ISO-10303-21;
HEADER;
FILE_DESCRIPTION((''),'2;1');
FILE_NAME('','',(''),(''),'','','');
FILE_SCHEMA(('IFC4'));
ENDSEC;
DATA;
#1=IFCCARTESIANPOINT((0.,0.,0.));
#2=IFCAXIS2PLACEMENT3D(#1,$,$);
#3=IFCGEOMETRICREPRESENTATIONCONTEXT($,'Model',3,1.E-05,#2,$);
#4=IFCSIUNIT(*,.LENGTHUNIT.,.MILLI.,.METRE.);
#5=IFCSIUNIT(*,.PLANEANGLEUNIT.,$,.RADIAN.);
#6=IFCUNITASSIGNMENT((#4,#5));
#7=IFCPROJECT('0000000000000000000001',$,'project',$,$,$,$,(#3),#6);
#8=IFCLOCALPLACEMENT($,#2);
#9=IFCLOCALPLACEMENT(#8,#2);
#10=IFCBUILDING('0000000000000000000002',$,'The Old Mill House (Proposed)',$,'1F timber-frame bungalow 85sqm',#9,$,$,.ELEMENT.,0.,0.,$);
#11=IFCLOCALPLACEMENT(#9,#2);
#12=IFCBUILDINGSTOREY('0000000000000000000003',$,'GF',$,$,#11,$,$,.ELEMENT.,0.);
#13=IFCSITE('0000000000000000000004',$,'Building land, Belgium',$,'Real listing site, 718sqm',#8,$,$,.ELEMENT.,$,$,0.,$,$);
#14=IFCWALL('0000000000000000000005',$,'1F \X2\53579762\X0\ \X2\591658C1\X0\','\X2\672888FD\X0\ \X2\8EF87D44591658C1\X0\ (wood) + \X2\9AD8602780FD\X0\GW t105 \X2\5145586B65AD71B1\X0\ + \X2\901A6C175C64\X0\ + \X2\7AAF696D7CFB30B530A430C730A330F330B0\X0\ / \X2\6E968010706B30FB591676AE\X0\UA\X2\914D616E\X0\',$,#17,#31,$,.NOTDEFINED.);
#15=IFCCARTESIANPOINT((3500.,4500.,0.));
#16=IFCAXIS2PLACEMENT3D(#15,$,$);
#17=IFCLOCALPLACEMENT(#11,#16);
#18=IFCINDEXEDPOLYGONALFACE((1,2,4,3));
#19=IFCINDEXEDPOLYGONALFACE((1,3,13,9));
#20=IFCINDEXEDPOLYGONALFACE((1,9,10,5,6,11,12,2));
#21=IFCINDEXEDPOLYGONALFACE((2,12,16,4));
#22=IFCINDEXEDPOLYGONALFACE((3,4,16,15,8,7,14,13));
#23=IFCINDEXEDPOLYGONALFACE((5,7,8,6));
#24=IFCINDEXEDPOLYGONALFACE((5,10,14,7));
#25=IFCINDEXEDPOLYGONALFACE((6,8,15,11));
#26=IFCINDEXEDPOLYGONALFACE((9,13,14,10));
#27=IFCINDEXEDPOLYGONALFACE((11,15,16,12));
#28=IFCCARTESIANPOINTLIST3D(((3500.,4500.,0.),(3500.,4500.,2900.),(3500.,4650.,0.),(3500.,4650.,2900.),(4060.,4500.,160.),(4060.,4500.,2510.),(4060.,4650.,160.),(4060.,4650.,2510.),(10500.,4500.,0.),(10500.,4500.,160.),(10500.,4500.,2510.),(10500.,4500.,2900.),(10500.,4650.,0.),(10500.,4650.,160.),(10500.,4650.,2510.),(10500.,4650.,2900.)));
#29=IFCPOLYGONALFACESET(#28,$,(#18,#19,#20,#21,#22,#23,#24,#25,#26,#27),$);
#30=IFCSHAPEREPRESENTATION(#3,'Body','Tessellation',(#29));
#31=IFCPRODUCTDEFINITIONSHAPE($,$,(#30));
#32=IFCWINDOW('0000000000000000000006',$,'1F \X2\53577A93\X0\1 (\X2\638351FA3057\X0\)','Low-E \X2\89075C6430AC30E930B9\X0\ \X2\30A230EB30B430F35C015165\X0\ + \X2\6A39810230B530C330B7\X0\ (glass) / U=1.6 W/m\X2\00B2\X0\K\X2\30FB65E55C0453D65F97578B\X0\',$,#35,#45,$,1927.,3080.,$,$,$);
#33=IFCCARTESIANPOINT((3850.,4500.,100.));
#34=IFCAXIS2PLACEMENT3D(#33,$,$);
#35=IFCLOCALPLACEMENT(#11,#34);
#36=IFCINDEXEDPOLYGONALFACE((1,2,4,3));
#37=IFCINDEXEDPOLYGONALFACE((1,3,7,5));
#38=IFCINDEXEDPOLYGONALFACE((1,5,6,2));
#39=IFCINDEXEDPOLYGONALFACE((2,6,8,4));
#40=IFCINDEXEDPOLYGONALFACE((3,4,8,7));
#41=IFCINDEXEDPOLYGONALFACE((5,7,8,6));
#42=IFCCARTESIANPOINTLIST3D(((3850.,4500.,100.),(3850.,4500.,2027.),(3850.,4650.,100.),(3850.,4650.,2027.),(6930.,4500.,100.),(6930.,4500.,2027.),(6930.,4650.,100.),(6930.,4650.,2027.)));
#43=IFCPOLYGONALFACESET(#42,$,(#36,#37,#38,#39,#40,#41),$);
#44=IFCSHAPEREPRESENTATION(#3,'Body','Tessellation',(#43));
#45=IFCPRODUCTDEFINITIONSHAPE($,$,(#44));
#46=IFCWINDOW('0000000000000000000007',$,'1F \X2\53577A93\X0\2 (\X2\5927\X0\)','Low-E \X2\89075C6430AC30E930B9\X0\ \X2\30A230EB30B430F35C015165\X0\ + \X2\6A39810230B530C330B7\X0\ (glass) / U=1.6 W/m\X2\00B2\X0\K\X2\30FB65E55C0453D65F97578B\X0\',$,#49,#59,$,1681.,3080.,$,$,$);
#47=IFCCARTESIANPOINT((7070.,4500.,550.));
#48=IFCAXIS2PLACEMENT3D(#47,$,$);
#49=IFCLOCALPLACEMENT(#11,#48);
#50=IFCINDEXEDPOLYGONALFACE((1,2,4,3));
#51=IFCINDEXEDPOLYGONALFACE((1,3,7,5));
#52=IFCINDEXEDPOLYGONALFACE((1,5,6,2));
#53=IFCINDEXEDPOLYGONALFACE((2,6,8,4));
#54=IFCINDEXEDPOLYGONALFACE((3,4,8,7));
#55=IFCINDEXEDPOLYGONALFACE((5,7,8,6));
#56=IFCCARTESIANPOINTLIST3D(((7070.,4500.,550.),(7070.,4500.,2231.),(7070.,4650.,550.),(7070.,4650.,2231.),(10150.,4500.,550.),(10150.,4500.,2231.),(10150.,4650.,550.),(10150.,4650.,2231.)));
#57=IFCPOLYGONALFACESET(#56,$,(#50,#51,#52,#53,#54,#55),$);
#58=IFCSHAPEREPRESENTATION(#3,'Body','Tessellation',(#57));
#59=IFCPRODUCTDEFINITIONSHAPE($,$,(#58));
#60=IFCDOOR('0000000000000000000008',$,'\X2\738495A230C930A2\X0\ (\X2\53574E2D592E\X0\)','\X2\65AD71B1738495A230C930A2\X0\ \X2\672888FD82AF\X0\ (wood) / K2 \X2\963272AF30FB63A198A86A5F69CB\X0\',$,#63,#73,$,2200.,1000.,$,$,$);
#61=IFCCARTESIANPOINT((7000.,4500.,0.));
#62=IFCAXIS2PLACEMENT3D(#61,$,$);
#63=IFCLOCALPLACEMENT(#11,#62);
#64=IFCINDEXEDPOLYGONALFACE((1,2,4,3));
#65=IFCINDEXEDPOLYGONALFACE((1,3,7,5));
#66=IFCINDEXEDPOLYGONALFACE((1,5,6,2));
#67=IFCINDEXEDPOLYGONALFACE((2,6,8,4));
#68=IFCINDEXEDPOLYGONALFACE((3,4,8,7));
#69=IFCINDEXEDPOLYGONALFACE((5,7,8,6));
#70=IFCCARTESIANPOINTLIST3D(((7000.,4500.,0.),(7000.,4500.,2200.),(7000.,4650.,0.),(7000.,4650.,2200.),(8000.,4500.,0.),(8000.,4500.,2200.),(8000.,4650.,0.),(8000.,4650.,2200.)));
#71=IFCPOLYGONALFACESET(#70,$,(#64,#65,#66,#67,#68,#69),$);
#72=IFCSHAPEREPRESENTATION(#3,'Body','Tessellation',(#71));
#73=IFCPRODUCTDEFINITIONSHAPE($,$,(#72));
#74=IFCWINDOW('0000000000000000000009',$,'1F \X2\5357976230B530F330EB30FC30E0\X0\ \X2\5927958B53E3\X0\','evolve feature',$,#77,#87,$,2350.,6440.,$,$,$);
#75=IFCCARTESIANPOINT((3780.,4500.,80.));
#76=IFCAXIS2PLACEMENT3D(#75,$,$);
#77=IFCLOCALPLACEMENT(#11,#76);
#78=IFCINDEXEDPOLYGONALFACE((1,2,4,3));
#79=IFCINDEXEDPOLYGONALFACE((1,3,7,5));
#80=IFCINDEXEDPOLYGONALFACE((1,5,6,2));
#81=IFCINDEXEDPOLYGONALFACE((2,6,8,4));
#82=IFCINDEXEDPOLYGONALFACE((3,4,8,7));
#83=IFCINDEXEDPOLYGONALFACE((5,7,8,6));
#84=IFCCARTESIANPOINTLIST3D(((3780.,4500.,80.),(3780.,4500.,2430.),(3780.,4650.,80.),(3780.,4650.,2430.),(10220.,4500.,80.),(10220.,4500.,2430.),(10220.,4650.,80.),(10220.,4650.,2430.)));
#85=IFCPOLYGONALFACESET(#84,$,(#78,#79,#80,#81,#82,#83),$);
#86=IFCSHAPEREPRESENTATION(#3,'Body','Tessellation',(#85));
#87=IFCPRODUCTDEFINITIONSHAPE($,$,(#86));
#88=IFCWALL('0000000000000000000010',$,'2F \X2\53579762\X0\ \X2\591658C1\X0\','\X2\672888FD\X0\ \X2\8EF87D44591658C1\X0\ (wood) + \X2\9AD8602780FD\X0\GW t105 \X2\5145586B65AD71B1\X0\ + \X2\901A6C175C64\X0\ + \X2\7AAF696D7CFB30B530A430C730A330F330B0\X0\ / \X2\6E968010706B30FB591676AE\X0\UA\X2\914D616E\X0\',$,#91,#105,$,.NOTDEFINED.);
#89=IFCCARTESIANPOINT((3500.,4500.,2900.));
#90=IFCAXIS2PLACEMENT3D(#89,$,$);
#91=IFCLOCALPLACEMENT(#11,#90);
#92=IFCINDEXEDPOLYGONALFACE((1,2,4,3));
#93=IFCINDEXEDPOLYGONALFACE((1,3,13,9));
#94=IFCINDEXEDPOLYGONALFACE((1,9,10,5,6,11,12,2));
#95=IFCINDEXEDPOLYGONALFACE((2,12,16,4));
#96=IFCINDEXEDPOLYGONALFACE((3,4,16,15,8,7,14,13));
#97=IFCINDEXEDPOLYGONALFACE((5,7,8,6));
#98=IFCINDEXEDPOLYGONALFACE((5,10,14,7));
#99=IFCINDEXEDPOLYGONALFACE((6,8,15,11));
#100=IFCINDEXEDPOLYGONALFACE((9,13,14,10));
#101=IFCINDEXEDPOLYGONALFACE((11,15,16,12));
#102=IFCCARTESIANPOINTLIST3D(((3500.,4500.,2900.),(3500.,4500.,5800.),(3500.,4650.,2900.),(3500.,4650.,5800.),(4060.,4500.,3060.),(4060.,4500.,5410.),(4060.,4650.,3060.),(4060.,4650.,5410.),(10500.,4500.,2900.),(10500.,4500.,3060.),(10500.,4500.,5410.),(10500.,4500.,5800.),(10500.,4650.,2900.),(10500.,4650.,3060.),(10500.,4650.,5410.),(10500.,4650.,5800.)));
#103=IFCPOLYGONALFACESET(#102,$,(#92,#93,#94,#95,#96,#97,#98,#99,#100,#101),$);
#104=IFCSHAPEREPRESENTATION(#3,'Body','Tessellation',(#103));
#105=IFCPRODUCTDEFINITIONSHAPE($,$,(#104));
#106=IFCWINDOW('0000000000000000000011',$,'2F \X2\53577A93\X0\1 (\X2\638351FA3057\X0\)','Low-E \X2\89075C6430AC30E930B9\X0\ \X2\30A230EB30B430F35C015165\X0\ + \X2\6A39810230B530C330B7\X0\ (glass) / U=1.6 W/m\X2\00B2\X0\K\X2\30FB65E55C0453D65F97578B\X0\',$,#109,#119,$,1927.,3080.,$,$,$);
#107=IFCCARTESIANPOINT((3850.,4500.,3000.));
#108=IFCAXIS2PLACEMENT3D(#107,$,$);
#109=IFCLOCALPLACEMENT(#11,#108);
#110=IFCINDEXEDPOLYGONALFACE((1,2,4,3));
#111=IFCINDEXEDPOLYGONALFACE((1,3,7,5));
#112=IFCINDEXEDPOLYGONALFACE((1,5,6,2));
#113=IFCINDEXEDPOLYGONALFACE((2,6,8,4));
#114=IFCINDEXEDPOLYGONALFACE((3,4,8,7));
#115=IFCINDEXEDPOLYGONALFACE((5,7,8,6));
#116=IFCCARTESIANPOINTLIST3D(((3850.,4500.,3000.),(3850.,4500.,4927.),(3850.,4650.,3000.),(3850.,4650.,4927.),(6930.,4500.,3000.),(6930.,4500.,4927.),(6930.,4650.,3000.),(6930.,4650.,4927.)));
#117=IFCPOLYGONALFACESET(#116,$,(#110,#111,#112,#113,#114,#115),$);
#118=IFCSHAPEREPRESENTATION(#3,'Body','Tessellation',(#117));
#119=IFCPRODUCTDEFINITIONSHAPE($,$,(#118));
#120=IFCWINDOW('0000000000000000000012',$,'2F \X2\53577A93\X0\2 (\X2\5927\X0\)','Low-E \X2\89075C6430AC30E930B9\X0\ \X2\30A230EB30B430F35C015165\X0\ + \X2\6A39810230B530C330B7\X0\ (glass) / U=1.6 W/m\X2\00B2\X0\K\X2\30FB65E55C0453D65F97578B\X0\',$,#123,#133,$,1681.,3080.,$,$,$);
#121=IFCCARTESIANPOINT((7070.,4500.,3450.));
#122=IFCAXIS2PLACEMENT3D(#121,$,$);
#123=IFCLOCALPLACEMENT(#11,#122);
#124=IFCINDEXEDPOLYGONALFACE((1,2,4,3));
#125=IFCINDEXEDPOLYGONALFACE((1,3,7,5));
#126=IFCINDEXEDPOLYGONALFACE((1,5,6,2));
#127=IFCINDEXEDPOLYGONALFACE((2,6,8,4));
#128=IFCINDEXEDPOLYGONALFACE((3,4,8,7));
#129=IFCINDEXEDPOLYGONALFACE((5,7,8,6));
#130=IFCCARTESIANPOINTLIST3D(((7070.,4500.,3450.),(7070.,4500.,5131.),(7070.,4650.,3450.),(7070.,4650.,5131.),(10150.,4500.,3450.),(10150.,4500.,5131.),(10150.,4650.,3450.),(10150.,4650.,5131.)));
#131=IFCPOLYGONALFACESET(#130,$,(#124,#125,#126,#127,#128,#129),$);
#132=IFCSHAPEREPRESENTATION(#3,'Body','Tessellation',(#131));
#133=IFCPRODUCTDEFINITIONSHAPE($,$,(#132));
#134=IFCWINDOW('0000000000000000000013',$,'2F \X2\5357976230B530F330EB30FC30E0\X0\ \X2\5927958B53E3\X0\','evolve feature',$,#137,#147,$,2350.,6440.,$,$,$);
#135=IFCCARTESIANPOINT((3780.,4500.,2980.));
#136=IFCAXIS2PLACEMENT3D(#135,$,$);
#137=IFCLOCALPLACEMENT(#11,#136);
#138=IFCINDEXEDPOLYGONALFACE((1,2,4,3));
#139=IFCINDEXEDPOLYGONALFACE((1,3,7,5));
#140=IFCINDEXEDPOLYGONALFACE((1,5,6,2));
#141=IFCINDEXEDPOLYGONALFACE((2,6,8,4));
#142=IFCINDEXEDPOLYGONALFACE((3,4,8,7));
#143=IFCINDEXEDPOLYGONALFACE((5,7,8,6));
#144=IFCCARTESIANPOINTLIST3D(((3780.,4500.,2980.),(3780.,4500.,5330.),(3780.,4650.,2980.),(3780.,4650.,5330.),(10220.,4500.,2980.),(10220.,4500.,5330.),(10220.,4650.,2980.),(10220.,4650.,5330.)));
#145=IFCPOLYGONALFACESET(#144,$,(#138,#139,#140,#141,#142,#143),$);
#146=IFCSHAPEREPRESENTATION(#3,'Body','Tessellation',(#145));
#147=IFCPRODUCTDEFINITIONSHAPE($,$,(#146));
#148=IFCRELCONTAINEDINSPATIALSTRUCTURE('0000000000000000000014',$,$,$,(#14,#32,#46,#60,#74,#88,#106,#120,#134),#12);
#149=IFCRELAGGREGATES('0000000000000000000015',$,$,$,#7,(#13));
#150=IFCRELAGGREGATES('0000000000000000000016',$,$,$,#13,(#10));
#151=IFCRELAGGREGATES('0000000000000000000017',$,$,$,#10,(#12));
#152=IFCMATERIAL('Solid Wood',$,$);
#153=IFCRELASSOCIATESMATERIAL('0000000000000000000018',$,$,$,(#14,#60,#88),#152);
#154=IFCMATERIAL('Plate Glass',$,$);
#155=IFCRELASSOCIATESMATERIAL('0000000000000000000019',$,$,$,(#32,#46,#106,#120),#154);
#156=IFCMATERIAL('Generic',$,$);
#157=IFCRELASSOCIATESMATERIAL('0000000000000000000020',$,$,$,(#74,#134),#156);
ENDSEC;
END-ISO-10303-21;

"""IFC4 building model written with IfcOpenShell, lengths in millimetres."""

from ifc_helpers import new_model, si_unit, frame, frame_2d, origin, place, context, project, spatial, rectangle, extrude, material, element, fill, save


model = new_model("IFC4")

# Units and contexts
model_context = context("Model", 3, precision=1e-05, world=origin())
ifc_project = project(units=[si_unit("LENGTHUNIT", "METRE", prefix="MILLI"), si_unit("PLANEANGLEUNIT", "RADIAN")], contexts=[model_context])

# Site, building, storey
site_placement = place(None, origin())
site = spatial("IfcSite", under=ifc_project, at=site_placement, Name="Building land, Belgium", ObjectType="Real listing site, 718sqm", CompositionType="ELEMENT", RefElevation=0.0)
building_placement = place(site_placement, origin())
building = spatial("IfcBuilding", under=site, at=building_placement, Name="The Old Mill House (Proposed)", ObjectType="1F timber-frame bungalow 85sqm", CompositionType="ELEMENT", ElevationOfRefHeight=0.0, ElevationOfTerrain=0.0)
storey_placement = place(building_placement, origin())
storey = spatial("IfcBuildingStorey", under=building, at=storey_placement, Name="GF", CompositionType="ELEMENT", Elevation=0.0)

# Shared definitions
ifc_material_1 = material(Name="Solid Wood")
ifc_material_2 = material(Name="Generic")

# Wall, openings, windows, door
wall_1_placement = place(storey_placement, frame((3500.0, 4500.0, 0.0)))
wall_1 = element("IfcWall", 1, at=wall_1_placement, inside=storey, material=ifc_material_1, Name="1F 南面 外壁", Description="木製 軸組外壁 (wood) + 高性能GW t105 充填断熱 + 通気層 + 窯業系サイディング / 準耐火・外皮UA配慮", PredefinedType="NOTDEFINED", context=model_context, shape_type="SweptSolid", body=[
    extrude(rectangle(XDim=7000.0, YDim=150.0, at=frame_2d((3500.0, 75.0))), frame((3500.0, 4500.0, 0.0)), (0.0, 0.0, 1.0), 2900.0),
])
opening_1_placement = place(storey_placement, frame((3850.0, 4500.0, 100.0)))
opening_1 = element("IfcOpeningElement", 2, at=opening_1_placement, cuts=wall_1, PredefinedType="NOTDEFINED", context=model_context, shape_type="SweptSolid", body=[
    extrude(rectangle(XDim=3080.0, YDim=150.0, at=frame_2d((1540.0, 75.0))), frame((3850.0, 4500.0, 100.0)), (0.0, 0.0, 1.0), 1927.0),
])
opening_2_placement = place(storey_placement, frame((7070.0, 4500.0, 550.0)))
opening_2 = element("IfcOpeningElement", 3, at=opening_2_placement, cuts=wall_1, PredefinedType="NOTDEFINED", context=model_context, shape_type="SweptSolid", body=[
    extrude(rectangle(XDim=3080.0, YDim=150.0, at=frame_2d((1540.0, 75.0))), frame((7070.0, 4500.0, 550.0)), (0.0, 0.0, 1.0), 1681.0),
])
opening_3_placement = place(storey_placement, frame((7000.0, 4500.0, 0.0)))
opening_3 = element("IfcOpeningElement", 4, at=opening_3_placement, cuts=wall_1, PredefinedType="NOTDEFINED", context=model_context, shape_type="SweptSolid", body=[
    extrude(rectangle(XDim=1000.0, YDim=150.0, at=frame_2d((500.0, 75.0))), frame((7000.0, 4500.0, 0.0)), (0.0, 0.0, 1.0), 2200.0),
])
opening_4_placement = place(storey_placement, frame((3780.0, 4500.0, 80.0)))
opening_4 = element("IfcOpeningElement", 5, at=opening_4_placement, cuts=wall_1, PredefinedType="NOTDEFINED", context=model_context, shape_type="SweptSolid", body=[
    extrude(rectangle(XDim=6440.0, YDim=150.0, at=frame_2d((3220.0, 75.0))), frame((3780.0, 4500.0, 80.0)), (0.0, 0.0, 1.0), 2350.0),
])
ifc_material_3 = material(Name="Plate Glass")
window_1_placement = place(storey_placement, frame((3850.0, 4500.0, 100.0)))
window_1 = element("IfcWindow", 6, at=window_1_placement, inside=storey, material=ifc_material_3, Name="1F 南窓1 (掃出し)", Description="Low-E 複層ガラス アルゴン封入 + 樹脂サッシ (glass) / U=1.6 W/m²K・日射取得型", OverallHeight=1927.0, OverallWidth=3080.0, context=model_context, shape_type="SweptSolid", body=[
    extrude(rectangle(XDim=3080.0, YDim=150.0, at=frame_2d((1540.0, 75.0))), frame((3850.0, 4500.0, 100.0)), (0.0, 0.0, 1.0), 1927.0),
])
fill(opening_1, window_1)
window_2_placement = place(storey_placement, frame((7070.0, 4500.0, 550.0)))
window_2 = element("IfcWindow", 7, at=window_2_placement, inside=storey, material=ifc_material_3, Name="1F 南窓2 (大)", Description="Low-E 複層ガラス アルゴン封入 + 樹脂サッシ (glass) / U=1.6 W/m²K・日射取得型", OverallHeight=1681.0, OverallWidth=3080.0, context=model_context, shape_type="SweptSolid", body=[
    extrude(rectangle(XDim=3080.0, YDim=150.0, at=frame_2d((1540.0, 75.0))), frame((7070.0, 4500.0, 550.0)), (0.0, 0.0, 1.0), 1681.0),
])
fill(opening_2, window_2)
door_placement = place(storey_placement, frame((7000.0, 4500.0, 0.0)))
door = element("IfcDoor", 8, at=door_placement, inside=storey, material=ifc_material_1, Name="玄関ドア (南中央)", Description="断熱玄関ドア 木製芯 (wood) / K2 防犯・採風機構", OverallHeight=2200.0, OverallWidth=1000.0, context=model_context, shape_type="SweptSolid", body=[
    extrude(rectangle(XDim=1000.0, YDim=150.0, at=frame_2d((500.0, 75.0))), frame((7000.0, 4500.0, 0.0)), (0.0, 0.0, 1.0), 2200.0),
])
fill(opening_3, door)
window_3_placement = place(storey_placement, frame((3780.0, 4500.0, 80.0)))
window_3 = element("IfcWindow", 9, at=window_3_placement, inside=storey, material=ifc_material_2, Name="1F 南面サンルーム 大開口", Description="evolve feature", OverallHeight=2350.0, OverallWidth=6440.0, context=model_context, shape_type="SweptSolid", body=[
    extrude(rectangle(XDim=6440.0, YDim=150.0, at=frame_2d((3220.0, 75.0))), frame((3780.0, 4500.0, 80.0)), (0.0, 0.0, 1.0), 2350.0),
])
fill(opening_4, window_3)

# Wall, openings, windows
wall_2_placement = place(storey_placement, frame((3500.0, 4500.0, 2900.0)))
wall_2 = element("IfcWall", 10, at=wall_2_placement, inside=storey, material=ifc_material_1, Name="2F 南面 外壁", Description="木製 軸組外壁 (wood) + 高性能GW t105 充填断熱 + 通気層 + 窯業系サイディング / 準耐火・外皮UA配慮", PredefinedType="NOTDEFINED", context=model_context, shape_type="SweptSolid", body=[
    extrude(rectangle(XDim=7000.0, YDim=150.0, at=frame_2d((3500.0, 75.0))), frame((3500.0, 4500.0, 2900.0)), (0.0, 0.0, 1.0), 2900.0),
])
opening_5_placement = place(storey_placement, frame((3850.0, 4500.0, 3000.0)))
opening_5 = element("IfcOpeningElement", 11, at=opening_5_placement, cuts=wall_2, PredefinedType="NOTDEFINED", context=model_context, shape_type="SweptSolid", body=[
    extrude(rectangle(XDim=3080.0, YDim=150.0, at=frame_2d((1540.0, 75.0))), frame((3850.0, 4500.0, 3000.0)), (0.0, 0.0, 1.0), 1927.0),
])
opening_6_placement = place(storey_placement, frame((7070.0, 4500.0, 3450.0)))
opening_6 = element("IfcOpeningElement", 12, at=opening_6_placement, cuts=wall_2, PredefinedType="NOTDEFINED", context=model_context, shape_type="SweptSolid", body=[
    extrude(rectangle(XDim=3080.0, YDim=150.0, at=frame_2d((1540.0, 75.0))), frame((7070.0, 4500.0, 3450.0)), (0.0, 0.0, 1.0), 1681.0),
])
opening_7_placement = place(storey_placement, frame((3780.0, 4500.0, 2980.0)))
opening_7 = element("IfcOpeningElement", 13, at=opening_7_placement, cuts=wall_2, PredefinedType="NOTDEFINED", context=model_context, shape_type="SweptSolid", body=[
    extrude(rectangle(XDim=6440.0, YDim=150.0, at=frame_2d((3220.0, 75.0))), frame((3780.0, 4500.0, 2980.0)), (0.0, 0.0, 1.0), 2350.0),
])
window_4_placement = place(storey_placement, frame((3850.0, 4500.0, 3000.0)))
window_4 = element("IfcWindow", 14, at=window_4_placement, inside=storey, material=ifc_material_3, Name="2F 南窓1 (掃出し)", Description="Low-E 複層ガラス アルゴン封入 + 樹脂サッシ (glass) / U=1.6 W/m²K・日射取得型", OverallHeight=1927.0, OverallWidth=3080.0, context=model_context, shape_type="SweptSolid", body=[
    extrude(rectangle(XDim=3080.0, YDim=150.0, at=frame_2d((1540.0, 75.0))), frame((3850.0, 4500.0, 3000.0)), (0.0, 0.0, 1.0), 1927.0),
])
fill(opening_5, window_4)
window_5_placement = place(storey_placement, frame((7070.0, 4500.0, 3450.0)))
window_5 = element("IfcWindow", 15, at=window_5_placement, inside=storey, material=ifc_material_3, Name="2F 南窓2 (大)", Description="Low-E 複層ガラス アルゴン封入 + 樹脂サッシ (glass) / U=1.6 W/m²K・日射取得型", OverallHeight=1681.0, OverallWidth=3080.0, context=model_context, shape_type="SweptSolid", body=[
    extrude(rectangle(XDim=3080.0, YDim=150.0, at=frame_2d((1540.0, 75.0))), frame((7070.0, 4500.0, 3450.0)), (0.0, 0.0, 1.0), 1681.0),
])
fill(opening_6, window_5)
window_6_placement = place(storey_placement, frame((3780.0, 4500.0, 2980.0)))
window_6 = element("IfcWindow", 16, at=window_6_placement, inside=storey, material=ifc_material_2, Name="2F 南面サンルーム 大開口", Description="evolve feature", OverallHeight=2350.0, OverallWidth=6440.0, context=model_context, shape_type="SweptSolid", body=[
    extrude(rectangle(XDim=6440.0, YDim=150.0, at=frame_2d((3220.0, 75.0))), frame((3780.0, 4500.0, 2980.0)), (0.0, 0.0, 1.0), 2350.0),
])
fill(opening_7, window_6)

save(model, "model.ifc")
